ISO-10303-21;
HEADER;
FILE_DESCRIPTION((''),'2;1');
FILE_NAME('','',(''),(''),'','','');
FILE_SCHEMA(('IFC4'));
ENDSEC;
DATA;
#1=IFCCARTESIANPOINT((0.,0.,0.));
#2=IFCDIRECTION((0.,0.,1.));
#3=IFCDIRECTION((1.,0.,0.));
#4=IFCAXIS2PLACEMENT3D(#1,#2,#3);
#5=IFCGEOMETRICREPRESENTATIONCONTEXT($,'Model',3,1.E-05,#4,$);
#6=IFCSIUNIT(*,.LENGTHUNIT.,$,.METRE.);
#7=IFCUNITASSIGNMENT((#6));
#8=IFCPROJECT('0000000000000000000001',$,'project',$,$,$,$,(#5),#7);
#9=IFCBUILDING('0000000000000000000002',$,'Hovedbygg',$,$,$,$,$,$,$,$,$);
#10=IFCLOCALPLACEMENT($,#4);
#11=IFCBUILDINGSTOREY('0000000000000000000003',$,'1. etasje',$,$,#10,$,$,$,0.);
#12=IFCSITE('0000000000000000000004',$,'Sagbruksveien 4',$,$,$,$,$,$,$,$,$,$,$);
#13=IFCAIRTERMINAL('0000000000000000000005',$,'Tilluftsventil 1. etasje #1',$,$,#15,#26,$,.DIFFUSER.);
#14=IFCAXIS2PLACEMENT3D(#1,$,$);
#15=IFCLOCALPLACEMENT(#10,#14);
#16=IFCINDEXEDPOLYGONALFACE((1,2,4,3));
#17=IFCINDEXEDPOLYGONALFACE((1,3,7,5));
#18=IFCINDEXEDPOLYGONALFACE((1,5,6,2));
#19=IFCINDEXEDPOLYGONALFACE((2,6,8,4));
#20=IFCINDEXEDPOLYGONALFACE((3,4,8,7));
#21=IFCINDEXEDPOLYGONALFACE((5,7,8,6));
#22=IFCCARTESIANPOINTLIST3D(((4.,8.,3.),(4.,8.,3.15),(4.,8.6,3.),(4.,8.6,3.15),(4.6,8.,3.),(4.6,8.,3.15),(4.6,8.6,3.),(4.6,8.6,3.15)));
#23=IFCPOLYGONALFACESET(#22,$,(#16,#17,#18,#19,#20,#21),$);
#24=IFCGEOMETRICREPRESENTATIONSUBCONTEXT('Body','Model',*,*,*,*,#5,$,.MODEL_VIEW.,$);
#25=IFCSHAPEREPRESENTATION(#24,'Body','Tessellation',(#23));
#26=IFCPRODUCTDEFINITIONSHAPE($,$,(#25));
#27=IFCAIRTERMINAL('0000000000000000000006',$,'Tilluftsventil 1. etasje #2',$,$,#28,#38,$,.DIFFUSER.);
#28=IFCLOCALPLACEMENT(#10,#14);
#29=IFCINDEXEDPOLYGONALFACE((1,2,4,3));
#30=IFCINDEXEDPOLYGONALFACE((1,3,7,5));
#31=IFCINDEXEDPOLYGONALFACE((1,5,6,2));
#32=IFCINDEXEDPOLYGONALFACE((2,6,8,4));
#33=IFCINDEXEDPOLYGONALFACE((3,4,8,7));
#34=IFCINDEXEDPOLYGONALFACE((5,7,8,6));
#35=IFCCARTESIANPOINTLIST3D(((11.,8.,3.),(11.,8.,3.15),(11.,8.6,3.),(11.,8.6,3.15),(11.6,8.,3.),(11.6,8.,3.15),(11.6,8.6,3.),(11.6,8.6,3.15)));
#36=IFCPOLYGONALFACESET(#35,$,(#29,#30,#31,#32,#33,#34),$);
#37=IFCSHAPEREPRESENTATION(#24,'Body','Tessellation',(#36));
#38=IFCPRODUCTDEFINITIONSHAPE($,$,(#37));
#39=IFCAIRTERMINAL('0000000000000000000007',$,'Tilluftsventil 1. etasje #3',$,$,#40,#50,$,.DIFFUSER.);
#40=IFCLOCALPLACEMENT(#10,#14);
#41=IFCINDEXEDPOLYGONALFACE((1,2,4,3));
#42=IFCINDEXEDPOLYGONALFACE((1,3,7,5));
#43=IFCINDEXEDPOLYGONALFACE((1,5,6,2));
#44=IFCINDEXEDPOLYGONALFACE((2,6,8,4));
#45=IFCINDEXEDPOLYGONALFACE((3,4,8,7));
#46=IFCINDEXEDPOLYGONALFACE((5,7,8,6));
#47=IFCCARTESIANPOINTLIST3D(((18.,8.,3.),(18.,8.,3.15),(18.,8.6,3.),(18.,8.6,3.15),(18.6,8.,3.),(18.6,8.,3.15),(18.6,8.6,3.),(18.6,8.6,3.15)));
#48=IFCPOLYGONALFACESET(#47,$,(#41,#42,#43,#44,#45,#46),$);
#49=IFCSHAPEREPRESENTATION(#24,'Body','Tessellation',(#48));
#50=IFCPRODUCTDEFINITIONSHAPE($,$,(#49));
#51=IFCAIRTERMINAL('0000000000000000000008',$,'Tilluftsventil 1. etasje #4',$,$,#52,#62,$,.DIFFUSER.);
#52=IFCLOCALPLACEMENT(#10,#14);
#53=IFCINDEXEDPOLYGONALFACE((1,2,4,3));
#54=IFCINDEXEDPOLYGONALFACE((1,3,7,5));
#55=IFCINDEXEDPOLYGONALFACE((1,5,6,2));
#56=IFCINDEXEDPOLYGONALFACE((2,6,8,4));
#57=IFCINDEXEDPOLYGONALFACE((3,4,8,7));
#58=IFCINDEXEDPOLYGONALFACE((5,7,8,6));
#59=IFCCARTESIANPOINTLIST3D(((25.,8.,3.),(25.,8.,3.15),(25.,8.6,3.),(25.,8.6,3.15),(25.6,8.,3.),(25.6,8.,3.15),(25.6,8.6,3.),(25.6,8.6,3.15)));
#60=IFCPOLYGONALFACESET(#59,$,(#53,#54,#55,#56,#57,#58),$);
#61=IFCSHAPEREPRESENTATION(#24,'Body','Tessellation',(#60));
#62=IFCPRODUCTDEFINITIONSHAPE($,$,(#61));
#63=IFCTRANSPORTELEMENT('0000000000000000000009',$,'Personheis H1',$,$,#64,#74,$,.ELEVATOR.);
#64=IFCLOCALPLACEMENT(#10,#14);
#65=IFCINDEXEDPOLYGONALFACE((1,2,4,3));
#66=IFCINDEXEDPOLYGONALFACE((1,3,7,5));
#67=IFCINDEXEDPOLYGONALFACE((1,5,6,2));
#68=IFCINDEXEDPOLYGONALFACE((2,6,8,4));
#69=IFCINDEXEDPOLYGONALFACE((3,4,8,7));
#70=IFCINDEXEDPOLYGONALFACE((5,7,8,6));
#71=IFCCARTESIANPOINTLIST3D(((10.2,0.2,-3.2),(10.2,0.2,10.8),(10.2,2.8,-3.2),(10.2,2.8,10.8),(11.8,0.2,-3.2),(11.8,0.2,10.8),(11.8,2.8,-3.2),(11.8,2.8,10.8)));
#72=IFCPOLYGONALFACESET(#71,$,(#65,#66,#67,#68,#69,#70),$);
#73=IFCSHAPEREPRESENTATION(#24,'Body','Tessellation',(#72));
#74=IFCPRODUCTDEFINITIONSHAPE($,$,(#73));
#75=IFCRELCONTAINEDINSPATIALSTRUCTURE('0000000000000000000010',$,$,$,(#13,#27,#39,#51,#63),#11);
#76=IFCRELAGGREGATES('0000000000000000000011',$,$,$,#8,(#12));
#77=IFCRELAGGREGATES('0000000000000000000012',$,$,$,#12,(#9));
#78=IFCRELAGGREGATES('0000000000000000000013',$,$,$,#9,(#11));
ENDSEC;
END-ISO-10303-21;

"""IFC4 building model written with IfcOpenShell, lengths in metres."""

from ifc_helpers import new_model, si_unit, frame, origin_with_axes, place, context, subcontext, project, spatial, line, indexed_curve, outline, extrude, element, save


model = new_model("IFC4")

# Units and contexts
model_context = context("Model", 3, precision=1e-05, world=origin_with_axes())
body_context = subcontext(model_context, "Body", "Model", "MODEL_VIEW")
ifc_project = project(units=[si_unit("LENGTHUNIT", "METRE")], contexts=[model_context])

# Site, building, storey
site = spatial("IfcSite", under=ifc_project, Name="Sagbruksveien 4")
building = spatial("IfcBuilding", under=site, Name="Hovedbygg")
storey_placement = place(None, origin_with_axes())
storey = spatial("IfcBuildingStorey", under=building, at=storey_placement, Name="1. etasje", Elevation=0.0)

# Air terminals
for number, where, z_axis, x_axis, name in (
    (1, (4.0, 8.0, 3.0), (0.0, 0.0, 1.0), (1.0, 0.0, 0.0), "Tilluftsventil 1. etasje #1"),
    (2, (11.0, 8.0, 3.0), (0.0, 0.0, 1.0), (1.0, 0.0, 0.0), "Tilluftsventil 1. etasje #2"),
    (3, (18.0, 8.0, 3.0), (0.0, 0.0, 1.0), (1.0, 0.0, 0.0), "Tilluftsventil 1. etasje #3"),
    (4, (25.0, 8.0, 3.0), (0.0, 0.0, 1.0), (1.0, 0.0, 0.0), "Tilluftsventil 1. etasje #4"),
):
    element("IfcAirTerminal", number, at=place(storey_placement, frame(where, z_axis=z_axis, x_axis=x_axis)), inside=storey, Name=name, PredefinedType="DIFFUSER", context=body_context, shape_type="SweptSolid", body=[
        extrude(outline(indexed_curve([(0.0, 0.0), (0.6, 0.0), (0.6, 0.6), (0.0, 0.6)], segments=[line(1, 2, 3, 4, 1)])), origin_with_axes(), (0.0, 0.0, 1.0), 0.15),
    ])

# Transport element
transport_element_placement = place(storey_placement, frame((10.2, 0.2, -3.2), z_axis=(0.0, 0.0, 1.0), x_axis=(1.0, 0.0, 0.0)))
element("IfcTransportElement", 5, at=transport_element_placement, inside=storey, Name="Personheis H1", PredefinedType="ELEVATOR", context=body_context, shape_type="SweptSolid", body=[
    extrude(outline(indexed_curve([(0.0, 0.0), (1.6, 0.0), (1.6, 2.6), (0.0, 2.6)], segments=[line(1, 2, 3, 4, 1)])), origin_with_axes(), (0.0, 0.0, 1.0), 14.0),
])

save(model, "model.ifc")
